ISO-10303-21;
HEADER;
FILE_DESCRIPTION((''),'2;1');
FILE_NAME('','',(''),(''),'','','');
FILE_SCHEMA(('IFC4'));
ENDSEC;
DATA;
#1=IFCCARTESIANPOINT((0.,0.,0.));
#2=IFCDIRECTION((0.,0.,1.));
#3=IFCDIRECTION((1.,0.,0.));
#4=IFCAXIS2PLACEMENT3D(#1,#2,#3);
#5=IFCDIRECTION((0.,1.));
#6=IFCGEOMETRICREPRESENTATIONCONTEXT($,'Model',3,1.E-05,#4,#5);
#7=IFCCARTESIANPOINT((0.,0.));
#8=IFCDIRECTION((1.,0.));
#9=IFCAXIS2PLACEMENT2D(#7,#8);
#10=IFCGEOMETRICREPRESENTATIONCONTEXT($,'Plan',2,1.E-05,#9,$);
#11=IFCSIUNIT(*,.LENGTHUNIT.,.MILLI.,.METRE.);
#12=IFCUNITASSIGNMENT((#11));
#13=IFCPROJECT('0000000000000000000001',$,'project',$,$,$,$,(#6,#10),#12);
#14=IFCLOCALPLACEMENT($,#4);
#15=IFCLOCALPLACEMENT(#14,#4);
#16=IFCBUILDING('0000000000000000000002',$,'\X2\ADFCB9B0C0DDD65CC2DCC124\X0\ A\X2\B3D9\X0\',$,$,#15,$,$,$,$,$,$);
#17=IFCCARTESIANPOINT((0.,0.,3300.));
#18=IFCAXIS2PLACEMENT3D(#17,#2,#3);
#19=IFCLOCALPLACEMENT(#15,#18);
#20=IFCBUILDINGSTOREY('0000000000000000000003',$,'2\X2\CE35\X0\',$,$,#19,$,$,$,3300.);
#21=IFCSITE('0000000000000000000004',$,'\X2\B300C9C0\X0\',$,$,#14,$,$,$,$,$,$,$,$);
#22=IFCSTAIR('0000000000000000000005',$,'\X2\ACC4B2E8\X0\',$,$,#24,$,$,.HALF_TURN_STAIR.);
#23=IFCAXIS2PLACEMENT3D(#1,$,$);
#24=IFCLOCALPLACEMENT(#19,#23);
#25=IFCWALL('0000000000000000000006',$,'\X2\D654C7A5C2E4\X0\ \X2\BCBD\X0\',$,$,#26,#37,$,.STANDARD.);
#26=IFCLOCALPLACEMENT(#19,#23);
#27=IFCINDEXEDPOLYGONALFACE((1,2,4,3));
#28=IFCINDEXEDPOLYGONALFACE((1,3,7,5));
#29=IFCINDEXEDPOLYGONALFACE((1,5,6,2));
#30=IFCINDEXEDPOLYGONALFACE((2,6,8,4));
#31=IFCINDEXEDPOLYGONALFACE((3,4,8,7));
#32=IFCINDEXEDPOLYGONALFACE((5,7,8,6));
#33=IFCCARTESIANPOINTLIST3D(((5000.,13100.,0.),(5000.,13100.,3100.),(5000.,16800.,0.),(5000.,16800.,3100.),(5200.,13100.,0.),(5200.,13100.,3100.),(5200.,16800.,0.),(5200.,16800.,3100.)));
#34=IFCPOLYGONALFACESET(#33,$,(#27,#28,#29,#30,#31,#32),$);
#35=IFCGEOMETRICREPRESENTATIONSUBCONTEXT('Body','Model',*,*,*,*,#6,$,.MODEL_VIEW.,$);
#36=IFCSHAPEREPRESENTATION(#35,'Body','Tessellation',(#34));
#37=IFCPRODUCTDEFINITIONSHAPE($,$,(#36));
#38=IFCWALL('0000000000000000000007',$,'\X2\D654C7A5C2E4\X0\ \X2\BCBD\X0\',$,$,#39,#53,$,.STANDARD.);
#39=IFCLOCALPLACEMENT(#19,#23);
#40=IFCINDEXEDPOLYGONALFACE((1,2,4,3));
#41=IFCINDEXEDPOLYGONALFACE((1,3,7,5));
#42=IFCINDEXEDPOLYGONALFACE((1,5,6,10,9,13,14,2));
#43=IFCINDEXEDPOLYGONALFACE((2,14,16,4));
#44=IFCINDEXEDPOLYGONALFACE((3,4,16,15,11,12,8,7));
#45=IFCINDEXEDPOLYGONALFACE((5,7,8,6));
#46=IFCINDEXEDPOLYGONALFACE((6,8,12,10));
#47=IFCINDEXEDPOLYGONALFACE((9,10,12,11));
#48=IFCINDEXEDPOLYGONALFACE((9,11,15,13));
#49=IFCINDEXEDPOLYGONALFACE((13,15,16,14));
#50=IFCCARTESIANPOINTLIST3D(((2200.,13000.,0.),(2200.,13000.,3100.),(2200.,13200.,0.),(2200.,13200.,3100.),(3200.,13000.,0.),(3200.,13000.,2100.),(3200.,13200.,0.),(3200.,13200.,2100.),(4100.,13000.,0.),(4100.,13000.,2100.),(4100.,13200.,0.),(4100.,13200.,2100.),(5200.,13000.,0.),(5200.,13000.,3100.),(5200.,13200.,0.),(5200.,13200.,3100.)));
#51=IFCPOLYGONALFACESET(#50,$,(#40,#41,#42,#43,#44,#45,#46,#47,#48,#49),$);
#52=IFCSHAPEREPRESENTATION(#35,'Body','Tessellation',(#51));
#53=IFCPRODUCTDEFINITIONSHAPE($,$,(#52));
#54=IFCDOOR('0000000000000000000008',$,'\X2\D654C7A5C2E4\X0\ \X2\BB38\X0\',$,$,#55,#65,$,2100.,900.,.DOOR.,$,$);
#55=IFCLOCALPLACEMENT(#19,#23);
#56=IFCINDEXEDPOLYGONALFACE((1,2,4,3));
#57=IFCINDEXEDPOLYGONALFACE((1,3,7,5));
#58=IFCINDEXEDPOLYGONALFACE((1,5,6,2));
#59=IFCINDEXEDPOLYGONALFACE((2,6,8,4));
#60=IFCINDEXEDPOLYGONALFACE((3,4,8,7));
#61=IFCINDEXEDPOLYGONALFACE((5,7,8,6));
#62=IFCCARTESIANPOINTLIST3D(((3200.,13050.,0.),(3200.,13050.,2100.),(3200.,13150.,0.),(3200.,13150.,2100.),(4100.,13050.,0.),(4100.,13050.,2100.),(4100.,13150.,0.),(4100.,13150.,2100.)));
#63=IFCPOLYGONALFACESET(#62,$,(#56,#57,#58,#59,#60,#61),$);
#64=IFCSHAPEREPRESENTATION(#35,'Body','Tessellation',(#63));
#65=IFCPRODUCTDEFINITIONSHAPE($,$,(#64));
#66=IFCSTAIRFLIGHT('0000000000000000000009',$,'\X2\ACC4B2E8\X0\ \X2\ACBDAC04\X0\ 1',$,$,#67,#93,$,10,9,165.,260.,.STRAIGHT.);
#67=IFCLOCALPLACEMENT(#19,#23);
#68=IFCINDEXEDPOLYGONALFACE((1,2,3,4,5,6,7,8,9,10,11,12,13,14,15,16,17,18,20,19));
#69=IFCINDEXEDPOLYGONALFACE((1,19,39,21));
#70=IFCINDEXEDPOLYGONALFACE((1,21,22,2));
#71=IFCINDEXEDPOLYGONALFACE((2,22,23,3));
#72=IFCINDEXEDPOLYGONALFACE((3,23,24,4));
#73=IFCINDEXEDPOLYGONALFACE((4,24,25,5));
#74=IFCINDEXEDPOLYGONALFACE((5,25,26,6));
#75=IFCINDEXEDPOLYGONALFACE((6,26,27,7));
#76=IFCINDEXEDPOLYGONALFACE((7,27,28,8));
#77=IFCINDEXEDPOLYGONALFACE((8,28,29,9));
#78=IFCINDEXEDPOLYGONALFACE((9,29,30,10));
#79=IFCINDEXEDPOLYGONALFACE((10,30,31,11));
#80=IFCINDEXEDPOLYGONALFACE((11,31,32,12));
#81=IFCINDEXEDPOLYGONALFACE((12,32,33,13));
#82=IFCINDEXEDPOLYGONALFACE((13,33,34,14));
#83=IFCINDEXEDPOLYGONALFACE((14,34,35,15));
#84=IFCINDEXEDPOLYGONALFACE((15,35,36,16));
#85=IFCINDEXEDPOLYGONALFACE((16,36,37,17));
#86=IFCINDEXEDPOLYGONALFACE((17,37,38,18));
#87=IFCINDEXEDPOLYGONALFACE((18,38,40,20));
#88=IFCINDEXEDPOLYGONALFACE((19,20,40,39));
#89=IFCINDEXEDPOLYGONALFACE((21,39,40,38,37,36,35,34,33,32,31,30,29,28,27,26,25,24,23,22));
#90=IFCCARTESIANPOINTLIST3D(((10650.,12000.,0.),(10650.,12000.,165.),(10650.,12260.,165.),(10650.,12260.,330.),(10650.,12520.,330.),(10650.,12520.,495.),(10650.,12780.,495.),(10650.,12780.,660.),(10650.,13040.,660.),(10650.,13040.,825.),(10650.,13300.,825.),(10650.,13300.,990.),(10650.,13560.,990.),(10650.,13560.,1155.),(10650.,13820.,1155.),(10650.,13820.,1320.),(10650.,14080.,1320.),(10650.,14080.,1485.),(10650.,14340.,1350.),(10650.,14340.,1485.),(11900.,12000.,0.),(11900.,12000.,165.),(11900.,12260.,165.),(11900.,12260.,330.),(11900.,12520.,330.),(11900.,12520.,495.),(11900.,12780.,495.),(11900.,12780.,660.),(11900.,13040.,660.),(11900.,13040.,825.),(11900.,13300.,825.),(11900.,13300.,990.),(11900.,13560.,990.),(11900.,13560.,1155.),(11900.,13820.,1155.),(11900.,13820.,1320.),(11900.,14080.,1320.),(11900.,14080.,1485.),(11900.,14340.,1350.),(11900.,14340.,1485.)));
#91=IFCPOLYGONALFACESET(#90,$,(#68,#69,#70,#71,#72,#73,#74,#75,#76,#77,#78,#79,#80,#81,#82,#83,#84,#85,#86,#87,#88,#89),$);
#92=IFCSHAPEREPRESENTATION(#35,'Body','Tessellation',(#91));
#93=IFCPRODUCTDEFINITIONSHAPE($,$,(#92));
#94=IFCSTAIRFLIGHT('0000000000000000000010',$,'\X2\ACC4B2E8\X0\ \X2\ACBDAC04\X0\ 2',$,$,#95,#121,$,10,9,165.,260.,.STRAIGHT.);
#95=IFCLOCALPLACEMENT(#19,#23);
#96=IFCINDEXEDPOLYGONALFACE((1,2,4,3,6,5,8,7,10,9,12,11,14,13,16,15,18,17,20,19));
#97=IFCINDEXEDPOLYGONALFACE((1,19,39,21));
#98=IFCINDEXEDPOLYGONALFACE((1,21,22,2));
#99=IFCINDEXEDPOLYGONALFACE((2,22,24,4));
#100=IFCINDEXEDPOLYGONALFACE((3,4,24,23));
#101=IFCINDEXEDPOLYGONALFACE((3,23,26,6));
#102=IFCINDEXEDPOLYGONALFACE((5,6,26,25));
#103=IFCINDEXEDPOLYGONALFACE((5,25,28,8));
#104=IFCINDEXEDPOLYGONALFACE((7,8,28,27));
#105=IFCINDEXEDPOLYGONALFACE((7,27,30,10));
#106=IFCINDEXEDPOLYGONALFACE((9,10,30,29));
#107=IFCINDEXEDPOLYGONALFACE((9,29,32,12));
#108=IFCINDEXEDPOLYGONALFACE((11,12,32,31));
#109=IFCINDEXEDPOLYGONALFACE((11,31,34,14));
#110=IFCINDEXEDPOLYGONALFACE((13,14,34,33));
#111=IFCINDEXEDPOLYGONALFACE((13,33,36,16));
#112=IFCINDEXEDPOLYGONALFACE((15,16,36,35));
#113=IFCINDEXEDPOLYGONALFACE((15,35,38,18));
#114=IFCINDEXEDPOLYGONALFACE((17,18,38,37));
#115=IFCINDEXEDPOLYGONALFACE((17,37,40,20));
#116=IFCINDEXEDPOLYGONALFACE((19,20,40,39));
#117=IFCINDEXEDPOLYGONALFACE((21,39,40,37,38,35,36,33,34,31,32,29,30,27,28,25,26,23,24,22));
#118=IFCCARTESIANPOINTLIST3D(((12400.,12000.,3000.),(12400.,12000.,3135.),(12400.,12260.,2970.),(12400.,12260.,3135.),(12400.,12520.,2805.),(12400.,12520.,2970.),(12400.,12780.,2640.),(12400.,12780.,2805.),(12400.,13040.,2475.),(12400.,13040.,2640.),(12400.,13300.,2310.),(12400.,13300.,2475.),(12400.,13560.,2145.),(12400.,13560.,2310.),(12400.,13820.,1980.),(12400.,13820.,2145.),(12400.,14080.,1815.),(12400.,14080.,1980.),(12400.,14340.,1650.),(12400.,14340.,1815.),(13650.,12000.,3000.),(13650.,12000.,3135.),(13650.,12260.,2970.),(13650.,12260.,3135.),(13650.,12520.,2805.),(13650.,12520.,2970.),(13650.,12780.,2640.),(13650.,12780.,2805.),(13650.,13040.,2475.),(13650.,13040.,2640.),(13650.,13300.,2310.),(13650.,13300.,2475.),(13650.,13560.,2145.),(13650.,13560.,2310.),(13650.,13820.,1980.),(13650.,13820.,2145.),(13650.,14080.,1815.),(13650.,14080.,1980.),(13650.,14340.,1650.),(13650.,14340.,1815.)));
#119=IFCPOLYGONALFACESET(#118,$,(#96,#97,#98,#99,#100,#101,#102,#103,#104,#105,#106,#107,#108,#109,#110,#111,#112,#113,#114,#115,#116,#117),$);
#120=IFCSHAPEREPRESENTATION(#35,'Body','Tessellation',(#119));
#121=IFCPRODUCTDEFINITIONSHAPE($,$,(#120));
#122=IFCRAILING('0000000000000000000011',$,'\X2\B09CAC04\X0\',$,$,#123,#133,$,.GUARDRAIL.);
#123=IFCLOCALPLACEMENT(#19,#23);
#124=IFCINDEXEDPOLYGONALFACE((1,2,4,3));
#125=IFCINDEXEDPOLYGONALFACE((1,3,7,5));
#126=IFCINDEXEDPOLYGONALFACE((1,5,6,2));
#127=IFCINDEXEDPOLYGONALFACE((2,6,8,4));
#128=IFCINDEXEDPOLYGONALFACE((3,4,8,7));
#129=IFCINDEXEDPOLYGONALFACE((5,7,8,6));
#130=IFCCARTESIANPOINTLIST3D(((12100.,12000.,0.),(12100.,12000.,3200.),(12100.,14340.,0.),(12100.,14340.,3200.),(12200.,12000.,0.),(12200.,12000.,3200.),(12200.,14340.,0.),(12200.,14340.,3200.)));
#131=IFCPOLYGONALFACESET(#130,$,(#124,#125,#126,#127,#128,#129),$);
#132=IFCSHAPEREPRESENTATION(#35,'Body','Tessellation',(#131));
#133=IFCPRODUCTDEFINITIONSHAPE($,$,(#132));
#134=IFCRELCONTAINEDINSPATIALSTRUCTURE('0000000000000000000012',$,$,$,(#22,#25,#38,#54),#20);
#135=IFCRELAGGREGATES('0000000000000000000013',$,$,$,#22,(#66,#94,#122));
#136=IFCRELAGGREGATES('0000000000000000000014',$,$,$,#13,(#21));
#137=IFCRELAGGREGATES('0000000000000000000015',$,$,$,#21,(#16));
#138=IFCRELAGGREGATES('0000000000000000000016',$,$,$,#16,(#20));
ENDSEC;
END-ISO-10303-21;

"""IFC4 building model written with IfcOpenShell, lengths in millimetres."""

from ifc_helpers import new_model, si_unit, direction, frame, origin_with_axes, origin_2d_with_axis, place, context, subcontext, project, spatial, polyline, outline, extrude, element, fill, aggregate, save


model = new_model("IFC4")

# Units and contexts
model_context = context("Model", 3, precision=1e-05, world=origin_with_axes(), true_north=direction((0.0, 1.0)))
plan_context = context("Plan", 2, precision=1e-05, world=origin_2d_with_axis())
body_context = subcontext(model_context, "Body", "Model", "MODEL_VIEW")
ifc_project = project(units=[si_unit("LENGTHUNIT", "METRE", prefix="MILLI")], contexts=[model_context, plan_context])

# Site, building, storey
site_placement = place(None, origin_with_axes())
site = spatial("IfcSite", under=ifc_project, at=site_placement, Name="대지")
building_placement = place(site_placement, origin_with_axes())
building = spatial("IfcBuilding", under=site, at=building_placement, Name="근린생활시설 A동")
storey_placement = place(building_placement, frame((0.0, 0.0, 3300.0), z_axis=(0.0, 0.0, 1.0), x_axis=(1.0, 0.0, 0.0)))
storey = spatial("IfcBuildingStorey", under=building, at=storey_placement, Name="2층", Elevation=3300.0)

# Stair
stair_placement = place(storey_placement, origin_with_axes())
stair = element("IfcStair", 1, at=stair_placement, inside=storey, Name="계단", PredefinedType="HALF_TURN_STAIR")

# Wall
wall_1_placement = place(storey_placement, origin_with_axes())
element("IfcWall", 2, at=wall_1_placement, inside=storey, Name="화장실 벽", PredefinedType="STANDARD", context=body_context, shape_type="SweptSolid", body=[
    extrude(outline(polyline([(5000.0, 13100.0), (5000.0, 16800.0), (5200.0, 16800.0), (5200.0, 13100.0), (5000.0, 13100.0)])), origin_with_axes(), (0.0, 0.0, 1.0), 3100.0),
])

# Wall, opening, door
wall_2_placement = place(storey_placement, origin_with_axes())
wall_2 = element("IfcWall", 3, at=wall_2_placement, inside=storey, Name="화장실 벽", PredefinedType="STANDARD", context=body_context, shape_type="SweptSolid", body=[
    extrude(outline(polyline([(2200.0, 13200.0), (5200.0, 13200.0), (5200.0, 13000.0), (2200.0, 13000.0), (2200.0, 13200.0)])), origin_with_axes(), (0.0, 0.0, 1.0), 3100.0),
])
opening_1_placement = place(storey_placement, origin_with_axes())
opening_1 = element("IfcOpeningElement", 4, at=opening_1_placement, cuts=wall_2, PredefinedType="OPENING", context=body_context, shape_type="SweptSolid", body=[
    extrude(outline(polyline([(3200.0, 12950.0), (4100.0, 12950.0), (4100.0, 13250.0), (3200.0, 13250.0), (3200.0, 12950.0)])), origin_with_axes(), (0.0, 0.0, 1.0), 2100.0),
])
door_1_placement = place(storey_placement, origin_with_axes())
door_1 = element("IfcDoor", 5, at=door_1_placement, inside=storey, Name="화장실 문", OverallHeight=2100.0, OverallWidth=900.0, PredefinedType="DOOR", context=body_context, shape_type="SweptSolid", body=[
    extrude(outline(polyline([(3200.0, 13050.0), (4100.0, 13050.0), (4100.0, 13150.0), (3200.0, 13150.0), (3200.0, 13050.0)])), origin_with_axes(), (0.0, 0.0, 1.0), 2100.0),
])
fill(opening_1, door_1)

# Stair flights
stair_flight_1_placement = place(stair_placement, origin_with_axes())
stair_flight_1 = element("IfcStairFlight", 6, at=stair_flight_1_placement, Name="계단 경간 1", NumberOfRisers=10, NumberOfTreads=9, PredefinedType="STRAIGHT", RiserHeight=165.0, TreadLength=260.0, context=body_context, shape_type="SweptSolid", body=[
    extrude(outline(polyline([(0.0, 0.0), (0.0, 165.0), (260.0, 165.0), (260.0, 330.0), (520.0, 330.0), (520.0, 495.0), (780.0, 495.0), (780.0, 660.0), (1040.0, 660.0), (1040.0, 825.0), (1300.0, 825.0), (1300.0, 990.0), (1560.0, 990.0), (1560.0, 1155.0), (1820.0, 1155.0), (1820.0, 1320.0), (2080.0, 1320.0), (2080.0, 1485.0), (2340.0, 1485.0), (2340.0, 1650.0), (2340.0, 1350.0), (0.0, 0.0)])), frame((10650.0, 12000.0, 0.0), z_axis=(1.0, 0.0, 0.0), x_axis=(0.0, 1.0, 0.0)), (0.0, 0.0, 1.0), 1250.0),
])
stair_flight_2_placement = place(stair_placement, origin_with_axes())
stair_flight_2 = element("IfcStairFlight", 7, at=stair_flight_2_placement, Name="계단 경간 2", NumberOfRisers=10, NumberOfTreads=9, PredefinedType="STRAIGHT", RiserHeight=165.0, TreadLength=260.0, context=body_context, shape_type="SweptSolid", body=[
    extrude(outline(polyline([(0.0, 0.0), (0.0, 165.0), (260.0, 165.0), (260.0, 330.0), (520.0, 330.0), (520.0, 495.0), (780.0, 495.0), (780.0, 660.0), (1040.0, 660.0), (1040.0, 825.0), (1300.0, 825.0), (1300.0, 990.0), (1560.0, 990.0), (1560.0, 1155.0), (1820.0, 1155.0), (1820.0, 1320.0), (2080.0, 1320.0), (2080.0, 1485.0), (2340.0, 1485.0), (2340.0, 1650.0), (2340.0, 1350.0), (0.0, 0.0)])), frame((13650.0, 14340.0, 1650.0), z_axis=(-1.0, 0.0, 0.0), x_axis=(0.0, -1.0, 0.0)), (0.0, 0.0, 1.0), 1250.0),
])

# Railing
railing_placement = place(stair_placement, origin_with_axes())
railing = element("IfcRailing", 8, at=railing_placement, Name="난간", PredefinedType="GUARDRAIL", context=body_context, shape_type="SweptSolid", body=[
    extrude(outline(polyline([(12100.0, 12000.0), (12200.0, 12000.0), (12200.0, 14340.0), (12100.0, 14340.0), (12100.0, 12000.0)])), origin_with_axes(), (0.0, 0.0, 1.0), 3200.0),
])
aggregate(stair, [stair_flight_1, stair_flight_2, railing])

save(model, "model.ifc")
